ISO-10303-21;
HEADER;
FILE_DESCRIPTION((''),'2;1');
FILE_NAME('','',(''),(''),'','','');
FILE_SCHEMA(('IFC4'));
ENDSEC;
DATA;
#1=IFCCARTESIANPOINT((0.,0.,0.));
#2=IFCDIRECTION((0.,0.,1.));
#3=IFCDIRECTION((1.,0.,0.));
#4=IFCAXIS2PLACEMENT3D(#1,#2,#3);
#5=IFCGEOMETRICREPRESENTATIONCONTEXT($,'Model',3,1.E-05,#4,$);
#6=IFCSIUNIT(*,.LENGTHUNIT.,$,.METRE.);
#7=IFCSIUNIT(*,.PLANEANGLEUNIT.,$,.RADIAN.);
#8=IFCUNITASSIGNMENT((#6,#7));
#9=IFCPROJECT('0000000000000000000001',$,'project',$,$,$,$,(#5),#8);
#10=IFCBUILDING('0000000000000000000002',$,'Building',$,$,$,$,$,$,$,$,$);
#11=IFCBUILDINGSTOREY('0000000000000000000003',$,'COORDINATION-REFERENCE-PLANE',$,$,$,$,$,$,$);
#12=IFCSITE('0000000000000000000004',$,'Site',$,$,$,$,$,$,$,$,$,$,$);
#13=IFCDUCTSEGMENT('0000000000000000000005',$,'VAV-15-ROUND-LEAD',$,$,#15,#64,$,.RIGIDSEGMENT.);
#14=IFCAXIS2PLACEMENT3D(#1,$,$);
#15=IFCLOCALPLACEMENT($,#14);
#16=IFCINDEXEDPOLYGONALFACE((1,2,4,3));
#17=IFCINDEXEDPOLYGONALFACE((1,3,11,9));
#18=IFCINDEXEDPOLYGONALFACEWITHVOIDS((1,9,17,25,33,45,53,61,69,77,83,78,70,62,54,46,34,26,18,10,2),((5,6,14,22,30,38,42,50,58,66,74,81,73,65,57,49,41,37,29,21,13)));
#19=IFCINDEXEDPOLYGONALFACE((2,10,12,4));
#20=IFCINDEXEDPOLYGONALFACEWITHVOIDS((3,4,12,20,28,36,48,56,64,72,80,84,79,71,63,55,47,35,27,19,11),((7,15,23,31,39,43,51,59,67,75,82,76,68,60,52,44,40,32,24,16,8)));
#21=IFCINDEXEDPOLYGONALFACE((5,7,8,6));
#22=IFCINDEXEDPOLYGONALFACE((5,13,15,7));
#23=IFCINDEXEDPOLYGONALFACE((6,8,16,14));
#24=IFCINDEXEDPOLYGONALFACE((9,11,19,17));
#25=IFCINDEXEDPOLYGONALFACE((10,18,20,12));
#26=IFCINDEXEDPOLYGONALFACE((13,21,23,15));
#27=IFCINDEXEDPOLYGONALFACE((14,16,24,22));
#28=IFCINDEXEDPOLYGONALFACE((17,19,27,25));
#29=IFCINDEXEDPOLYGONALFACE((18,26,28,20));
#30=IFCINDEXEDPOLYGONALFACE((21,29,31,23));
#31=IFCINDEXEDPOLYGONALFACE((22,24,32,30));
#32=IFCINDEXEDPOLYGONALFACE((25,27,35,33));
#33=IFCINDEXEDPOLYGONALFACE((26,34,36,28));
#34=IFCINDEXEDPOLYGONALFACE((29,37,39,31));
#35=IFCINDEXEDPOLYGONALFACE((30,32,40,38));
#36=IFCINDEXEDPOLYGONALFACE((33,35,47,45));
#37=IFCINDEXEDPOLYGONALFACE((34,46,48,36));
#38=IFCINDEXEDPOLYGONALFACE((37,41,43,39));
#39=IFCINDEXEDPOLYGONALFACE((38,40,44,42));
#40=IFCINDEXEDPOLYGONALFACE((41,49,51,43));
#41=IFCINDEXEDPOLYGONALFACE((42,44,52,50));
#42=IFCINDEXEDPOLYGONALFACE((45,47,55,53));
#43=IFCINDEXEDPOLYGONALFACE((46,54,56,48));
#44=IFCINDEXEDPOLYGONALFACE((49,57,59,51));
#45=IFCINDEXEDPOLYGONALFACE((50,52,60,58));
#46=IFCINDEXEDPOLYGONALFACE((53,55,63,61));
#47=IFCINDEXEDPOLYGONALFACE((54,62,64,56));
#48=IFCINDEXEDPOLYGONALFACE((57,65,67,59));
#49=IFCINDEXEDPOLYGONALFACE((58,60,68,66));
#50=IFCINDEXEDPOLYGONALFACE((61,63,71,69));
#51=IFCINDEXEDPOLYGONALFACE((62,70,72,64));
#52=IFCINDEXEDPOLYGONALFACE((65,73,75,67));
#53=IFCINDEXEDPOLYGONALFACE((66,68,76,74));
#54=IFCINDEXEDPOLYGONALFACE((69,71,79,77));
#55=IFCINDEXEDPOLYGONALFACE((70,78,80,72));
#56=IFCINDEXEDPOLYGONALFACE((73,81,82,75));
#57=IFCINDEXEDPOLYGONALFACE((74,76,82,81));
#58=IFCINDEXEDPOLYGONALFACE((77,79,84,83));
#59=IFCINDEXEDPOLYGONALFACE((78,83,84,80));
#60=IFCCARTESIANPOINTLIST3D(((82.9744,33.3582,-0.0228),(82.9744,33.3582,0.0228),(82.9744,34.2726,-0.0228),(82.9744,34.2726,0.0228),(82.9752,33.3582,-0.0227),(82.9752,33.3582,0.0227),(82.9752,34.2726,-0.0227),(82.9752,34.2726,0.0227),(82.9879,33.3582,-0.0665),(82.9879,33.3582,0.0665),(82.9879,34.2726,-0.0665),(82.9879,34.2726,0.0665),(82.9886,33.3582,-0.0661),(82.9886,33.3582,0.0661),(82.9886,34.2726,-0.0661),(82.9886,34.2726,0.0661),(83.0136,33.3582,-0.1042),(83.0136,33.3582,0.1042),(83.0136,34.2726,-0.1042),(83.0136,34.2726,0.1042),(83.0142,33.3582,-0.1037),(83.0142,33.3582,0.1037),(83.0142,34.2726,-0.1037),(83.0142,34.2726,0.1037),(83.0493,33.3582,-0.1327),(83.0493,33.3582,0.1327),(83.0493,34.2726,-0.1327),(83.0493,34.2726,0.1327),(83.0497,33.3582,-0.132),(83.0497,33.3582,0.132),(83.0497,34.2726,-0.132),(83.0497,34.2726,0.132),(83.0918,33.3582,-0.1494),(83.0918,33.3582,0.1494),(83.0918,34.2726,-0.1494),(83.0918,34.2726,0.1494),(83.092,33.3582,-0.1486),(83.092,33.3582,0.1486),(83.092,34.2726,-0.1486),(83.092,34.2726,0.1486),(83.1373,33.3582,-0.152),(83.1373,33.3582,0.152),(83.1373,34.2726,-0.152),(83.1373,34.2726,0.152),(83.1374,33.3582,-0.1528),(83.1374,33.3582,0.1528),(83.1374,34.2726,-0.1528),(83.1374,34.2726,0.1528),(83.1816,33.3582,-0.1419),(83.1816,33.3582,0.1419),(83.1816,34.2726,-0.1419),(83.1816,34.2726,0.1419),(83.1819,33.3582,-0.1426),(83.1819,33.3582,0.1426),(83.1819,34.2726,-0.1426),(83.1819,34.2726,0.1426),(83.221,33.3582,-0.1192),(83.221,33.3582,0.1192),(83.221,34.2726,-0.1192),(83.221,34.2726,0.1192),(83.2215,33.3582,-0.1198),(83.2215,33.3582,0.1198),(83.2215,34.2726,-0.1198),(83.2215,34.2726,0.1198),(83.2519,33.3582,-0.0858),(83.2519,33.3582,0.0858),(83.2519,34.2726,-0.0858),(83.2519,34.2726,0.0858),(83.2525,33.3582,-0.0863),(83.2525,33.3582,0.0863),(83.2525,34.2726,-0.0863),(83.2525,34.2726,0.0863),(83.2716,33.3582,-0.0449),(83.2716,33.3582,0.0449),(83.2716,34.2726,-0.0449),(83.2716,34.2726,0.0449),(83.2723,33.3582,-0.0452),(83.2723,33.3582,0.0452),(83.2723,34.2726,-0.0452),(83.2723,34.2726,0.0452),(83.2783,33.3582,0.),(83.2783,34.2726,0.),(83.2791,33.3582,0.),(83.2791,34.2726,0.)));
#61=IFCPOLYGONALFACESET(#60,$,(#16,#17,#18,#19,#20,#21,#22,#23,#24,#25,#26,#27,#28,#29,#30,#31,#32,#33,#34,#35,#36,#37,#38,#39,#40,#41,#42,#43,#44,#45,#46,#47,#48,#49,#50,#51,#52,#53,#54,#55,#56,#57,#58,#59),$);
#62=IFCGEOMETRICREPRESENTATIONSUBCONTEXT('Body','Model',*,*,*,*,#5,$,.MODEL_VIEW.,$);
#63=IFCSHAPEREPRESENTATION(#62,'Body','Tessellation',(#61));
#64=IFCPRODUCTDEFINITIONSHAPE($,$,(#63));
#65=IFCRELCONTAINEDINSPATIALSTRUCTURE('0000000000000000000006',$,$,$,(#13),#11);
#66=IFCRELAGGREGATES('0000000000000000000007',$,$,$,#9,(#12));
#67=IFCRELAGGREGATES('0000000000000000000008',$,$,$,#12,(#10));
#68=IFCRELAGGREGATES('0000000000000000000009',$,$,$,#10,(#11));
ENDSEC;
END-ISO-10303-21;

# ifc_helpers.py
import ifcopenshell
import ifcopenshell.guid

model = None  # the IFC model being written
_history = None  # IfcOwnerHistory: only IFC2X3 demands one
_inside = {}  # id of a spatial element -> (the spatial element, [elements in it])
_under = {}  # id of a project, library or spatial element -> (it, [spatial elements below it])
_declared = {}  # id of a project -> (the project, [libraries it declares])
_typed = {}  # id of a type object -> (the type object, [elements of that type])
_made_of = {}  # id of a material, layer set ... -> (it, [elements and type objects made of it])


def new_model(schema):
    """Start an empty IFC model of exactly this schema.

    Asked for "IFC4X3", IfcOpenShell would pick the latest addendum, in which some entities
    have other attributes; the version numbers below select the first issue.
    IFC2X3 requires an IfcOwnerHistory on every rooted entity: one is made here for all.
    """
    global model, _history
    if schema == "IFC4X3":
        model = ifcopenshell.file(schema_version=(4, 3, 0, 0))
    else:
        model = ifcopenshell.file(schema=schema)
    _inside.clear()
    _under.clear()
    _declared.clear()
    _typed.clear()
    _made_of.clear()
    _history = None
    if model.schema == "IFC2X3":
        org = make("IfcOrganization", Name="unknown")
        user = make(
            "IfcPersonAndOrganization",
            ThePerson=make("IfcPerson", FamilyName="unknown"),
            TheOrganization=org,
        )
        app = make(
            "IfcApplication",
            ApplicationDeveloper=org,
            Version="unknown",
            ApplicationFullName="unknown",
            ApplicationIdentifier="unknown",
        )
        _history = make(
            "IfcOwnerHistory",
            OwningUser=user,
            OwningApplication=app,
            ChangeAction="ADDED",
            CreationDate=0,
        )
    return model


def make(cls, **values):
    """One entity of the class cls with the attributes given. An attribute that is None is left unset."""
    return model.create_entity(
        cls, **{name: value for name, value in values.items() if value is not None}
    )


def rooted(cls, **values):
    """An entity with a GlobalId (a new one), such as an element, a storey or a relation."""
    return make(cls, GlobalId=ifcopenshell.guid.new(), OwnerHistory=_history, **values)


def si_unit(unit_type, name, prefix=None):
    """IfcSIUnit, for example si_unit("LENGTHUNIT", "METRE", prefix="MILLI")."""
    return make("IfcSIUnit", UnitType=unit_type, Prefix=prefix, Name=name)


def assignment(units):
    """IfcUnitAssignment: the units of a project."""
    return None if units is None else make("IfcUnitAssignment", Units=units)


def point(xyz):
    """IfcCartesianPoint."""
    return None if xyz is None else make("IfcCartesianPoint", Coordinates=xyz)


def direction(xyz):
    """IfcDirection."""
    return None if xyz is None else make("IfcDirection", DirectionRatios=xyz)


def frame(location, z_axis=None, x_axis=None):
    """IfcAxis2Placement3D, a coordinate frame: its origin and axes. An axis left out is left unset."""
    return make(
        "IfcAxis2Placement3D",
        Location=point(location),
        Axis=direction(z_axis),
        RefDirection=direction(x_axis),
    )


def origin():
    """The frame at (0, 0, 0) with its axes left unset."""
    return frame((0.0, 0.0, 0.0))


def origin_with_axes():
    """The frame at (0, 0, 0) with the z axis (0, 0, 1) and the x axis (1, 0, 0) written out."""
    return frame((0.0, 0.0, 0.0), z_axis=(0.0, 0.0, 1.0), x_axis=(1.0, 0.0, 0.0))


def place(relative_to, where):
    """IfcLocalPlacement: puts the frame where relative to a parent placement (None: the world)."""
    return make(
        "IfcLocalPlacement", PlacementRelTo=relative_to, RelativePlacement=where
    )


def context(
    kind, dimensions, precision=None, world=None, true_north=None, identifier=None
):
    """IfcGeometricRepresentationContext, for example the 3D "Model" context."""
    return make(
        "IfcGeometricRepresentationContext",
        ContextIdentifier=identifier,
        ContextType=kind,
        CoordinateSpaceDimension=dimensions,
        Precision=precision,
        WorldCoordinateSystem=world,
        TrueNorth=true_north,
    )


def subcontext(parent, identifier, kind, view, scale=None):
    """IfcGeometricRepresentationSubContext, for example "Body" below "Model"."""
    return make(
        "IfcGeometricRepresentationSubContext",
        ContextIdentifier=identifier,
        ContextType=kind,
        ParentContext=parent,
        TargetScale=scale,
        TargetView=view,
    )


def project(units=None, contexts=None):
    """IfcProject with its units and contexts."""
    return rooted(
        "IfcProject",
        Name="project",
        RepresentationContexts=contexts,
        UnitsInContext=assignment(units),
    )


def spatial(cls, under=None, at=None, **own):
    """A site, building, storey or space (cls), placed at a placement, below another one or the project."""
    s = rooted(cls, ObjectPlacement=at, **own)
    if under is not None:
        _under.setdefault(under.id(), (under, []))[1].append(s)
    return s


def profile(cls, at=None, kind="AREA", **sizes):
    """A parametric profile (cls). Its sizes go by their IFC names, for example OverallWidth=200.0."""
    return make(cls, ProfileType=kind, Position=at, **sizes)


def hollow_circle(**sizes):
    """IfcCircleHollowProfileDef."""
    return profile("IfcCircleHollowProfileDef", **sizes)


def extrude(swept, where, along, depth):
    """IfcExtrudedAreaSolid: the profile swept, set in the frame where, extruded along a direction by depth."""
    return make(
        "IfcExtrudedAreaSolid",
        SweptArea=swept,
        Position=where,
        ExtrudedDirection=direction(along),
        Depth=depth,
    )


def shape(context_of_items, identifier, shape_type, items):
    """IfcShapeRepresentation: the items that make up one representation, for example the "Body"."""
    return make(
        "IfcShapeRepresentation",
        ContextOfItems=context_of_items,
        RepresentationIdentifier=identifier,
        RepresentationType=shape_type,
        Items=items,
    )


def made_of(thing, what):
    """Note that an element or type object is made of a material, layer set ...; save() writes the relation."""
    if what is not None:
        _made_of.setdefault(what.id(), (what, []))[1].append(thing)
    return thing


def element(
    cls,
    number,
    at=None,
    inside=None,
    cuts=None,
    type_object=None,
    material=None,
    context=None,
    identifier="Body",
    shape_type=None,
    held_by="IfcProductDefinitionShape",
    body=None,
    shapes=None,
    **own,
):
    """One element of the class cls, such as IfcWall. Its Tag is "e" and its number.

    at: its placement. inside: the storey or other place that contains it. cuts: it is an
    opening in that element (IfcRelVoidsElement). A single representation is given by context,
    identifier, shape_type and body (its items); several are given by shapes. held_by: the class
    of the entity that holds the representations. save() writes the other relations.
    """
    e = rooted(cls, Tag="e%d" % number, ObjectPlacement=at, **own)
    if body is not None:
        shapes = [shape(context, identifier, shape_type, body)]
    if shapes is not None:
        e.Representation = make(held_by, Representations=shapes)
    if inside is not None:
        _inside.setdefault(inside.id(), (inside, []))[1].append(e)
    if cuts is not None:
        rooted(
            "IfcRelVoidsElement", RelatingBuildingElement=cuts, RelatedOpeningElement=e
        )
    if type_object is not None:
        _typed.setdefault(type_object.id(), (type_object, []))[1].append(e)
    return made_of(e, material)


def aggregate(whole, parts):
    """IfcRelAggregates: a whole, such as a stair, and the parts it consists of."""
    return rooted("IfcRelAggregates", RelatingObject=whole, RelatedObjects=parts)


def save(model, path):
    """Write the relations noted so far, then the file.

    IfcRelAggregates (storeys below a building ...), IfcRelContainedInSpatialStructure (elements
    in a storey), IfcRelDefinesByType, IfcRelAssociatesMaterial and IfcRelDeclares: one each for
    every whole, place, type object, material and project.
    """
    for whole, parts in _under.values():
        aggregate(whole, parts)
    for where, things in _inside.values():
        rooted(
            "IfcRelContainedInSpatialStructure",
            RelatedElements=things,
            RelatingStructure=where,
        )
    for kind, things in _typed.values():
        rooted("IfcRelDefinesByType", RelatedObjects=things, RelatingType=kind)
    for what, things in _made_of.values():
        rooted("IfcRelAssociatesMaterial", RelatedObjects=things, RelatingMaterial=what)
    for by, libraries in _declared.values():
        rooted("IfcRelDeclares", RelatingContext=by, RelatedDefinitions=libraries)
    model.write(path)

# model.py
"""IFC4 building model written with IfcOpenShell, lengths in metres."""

from ifc_helpers import new_model, si_unit, frame, origin, origin_with_axes, place, context, subcontext, project, spatial, hollow_circle, extrude, element, save


model = new_model("IFC4")

# Units and contexts
model_context = context("Model", 3, precision=1e-05, world=origin_with_axes())
body_context_1 = subcontext(model_context, "Body", "Model", "MODEL_VIEW")
ifc_project = project(units=[si_unit("LENGTHUNIT", "METRE"), si_unit("PLANEANGLEUNIT", "RADIAN")], contexts=[model_context])

# Site, building, storey
site = spatial("IfcSite", under=ifc_project, Name="Site")
building = spatial("IfcBuilding", under=site, Name="Building")
storey = spatial("IfcBuildingStorey", under=building, Name="COORDINATION-REFERENCE-PLANE")

# Duct segment
duct_segment_1_placement = place(None, frame((83.1259, 34.2726, 0.0), z_axis=(0.0, -1.0, 0.0), x_axis=(1.0, 0.0, 0.0)))
element("IfcDuctSegment", 1, at=duct_segment_1_placement, inside=storey, Name="VAV-15-ROUND-LEAD", PredefinedType="RIGIDSEGMENT", context=body_context_1, shape_type="SweptSolid", body=[
    extrude(hollow_circle(Radius=0.1532, WallThickness=0.0008), origin(), (0.0, 0.0, 1.0), 0.9144),
])

save(model, "model.ifc")
